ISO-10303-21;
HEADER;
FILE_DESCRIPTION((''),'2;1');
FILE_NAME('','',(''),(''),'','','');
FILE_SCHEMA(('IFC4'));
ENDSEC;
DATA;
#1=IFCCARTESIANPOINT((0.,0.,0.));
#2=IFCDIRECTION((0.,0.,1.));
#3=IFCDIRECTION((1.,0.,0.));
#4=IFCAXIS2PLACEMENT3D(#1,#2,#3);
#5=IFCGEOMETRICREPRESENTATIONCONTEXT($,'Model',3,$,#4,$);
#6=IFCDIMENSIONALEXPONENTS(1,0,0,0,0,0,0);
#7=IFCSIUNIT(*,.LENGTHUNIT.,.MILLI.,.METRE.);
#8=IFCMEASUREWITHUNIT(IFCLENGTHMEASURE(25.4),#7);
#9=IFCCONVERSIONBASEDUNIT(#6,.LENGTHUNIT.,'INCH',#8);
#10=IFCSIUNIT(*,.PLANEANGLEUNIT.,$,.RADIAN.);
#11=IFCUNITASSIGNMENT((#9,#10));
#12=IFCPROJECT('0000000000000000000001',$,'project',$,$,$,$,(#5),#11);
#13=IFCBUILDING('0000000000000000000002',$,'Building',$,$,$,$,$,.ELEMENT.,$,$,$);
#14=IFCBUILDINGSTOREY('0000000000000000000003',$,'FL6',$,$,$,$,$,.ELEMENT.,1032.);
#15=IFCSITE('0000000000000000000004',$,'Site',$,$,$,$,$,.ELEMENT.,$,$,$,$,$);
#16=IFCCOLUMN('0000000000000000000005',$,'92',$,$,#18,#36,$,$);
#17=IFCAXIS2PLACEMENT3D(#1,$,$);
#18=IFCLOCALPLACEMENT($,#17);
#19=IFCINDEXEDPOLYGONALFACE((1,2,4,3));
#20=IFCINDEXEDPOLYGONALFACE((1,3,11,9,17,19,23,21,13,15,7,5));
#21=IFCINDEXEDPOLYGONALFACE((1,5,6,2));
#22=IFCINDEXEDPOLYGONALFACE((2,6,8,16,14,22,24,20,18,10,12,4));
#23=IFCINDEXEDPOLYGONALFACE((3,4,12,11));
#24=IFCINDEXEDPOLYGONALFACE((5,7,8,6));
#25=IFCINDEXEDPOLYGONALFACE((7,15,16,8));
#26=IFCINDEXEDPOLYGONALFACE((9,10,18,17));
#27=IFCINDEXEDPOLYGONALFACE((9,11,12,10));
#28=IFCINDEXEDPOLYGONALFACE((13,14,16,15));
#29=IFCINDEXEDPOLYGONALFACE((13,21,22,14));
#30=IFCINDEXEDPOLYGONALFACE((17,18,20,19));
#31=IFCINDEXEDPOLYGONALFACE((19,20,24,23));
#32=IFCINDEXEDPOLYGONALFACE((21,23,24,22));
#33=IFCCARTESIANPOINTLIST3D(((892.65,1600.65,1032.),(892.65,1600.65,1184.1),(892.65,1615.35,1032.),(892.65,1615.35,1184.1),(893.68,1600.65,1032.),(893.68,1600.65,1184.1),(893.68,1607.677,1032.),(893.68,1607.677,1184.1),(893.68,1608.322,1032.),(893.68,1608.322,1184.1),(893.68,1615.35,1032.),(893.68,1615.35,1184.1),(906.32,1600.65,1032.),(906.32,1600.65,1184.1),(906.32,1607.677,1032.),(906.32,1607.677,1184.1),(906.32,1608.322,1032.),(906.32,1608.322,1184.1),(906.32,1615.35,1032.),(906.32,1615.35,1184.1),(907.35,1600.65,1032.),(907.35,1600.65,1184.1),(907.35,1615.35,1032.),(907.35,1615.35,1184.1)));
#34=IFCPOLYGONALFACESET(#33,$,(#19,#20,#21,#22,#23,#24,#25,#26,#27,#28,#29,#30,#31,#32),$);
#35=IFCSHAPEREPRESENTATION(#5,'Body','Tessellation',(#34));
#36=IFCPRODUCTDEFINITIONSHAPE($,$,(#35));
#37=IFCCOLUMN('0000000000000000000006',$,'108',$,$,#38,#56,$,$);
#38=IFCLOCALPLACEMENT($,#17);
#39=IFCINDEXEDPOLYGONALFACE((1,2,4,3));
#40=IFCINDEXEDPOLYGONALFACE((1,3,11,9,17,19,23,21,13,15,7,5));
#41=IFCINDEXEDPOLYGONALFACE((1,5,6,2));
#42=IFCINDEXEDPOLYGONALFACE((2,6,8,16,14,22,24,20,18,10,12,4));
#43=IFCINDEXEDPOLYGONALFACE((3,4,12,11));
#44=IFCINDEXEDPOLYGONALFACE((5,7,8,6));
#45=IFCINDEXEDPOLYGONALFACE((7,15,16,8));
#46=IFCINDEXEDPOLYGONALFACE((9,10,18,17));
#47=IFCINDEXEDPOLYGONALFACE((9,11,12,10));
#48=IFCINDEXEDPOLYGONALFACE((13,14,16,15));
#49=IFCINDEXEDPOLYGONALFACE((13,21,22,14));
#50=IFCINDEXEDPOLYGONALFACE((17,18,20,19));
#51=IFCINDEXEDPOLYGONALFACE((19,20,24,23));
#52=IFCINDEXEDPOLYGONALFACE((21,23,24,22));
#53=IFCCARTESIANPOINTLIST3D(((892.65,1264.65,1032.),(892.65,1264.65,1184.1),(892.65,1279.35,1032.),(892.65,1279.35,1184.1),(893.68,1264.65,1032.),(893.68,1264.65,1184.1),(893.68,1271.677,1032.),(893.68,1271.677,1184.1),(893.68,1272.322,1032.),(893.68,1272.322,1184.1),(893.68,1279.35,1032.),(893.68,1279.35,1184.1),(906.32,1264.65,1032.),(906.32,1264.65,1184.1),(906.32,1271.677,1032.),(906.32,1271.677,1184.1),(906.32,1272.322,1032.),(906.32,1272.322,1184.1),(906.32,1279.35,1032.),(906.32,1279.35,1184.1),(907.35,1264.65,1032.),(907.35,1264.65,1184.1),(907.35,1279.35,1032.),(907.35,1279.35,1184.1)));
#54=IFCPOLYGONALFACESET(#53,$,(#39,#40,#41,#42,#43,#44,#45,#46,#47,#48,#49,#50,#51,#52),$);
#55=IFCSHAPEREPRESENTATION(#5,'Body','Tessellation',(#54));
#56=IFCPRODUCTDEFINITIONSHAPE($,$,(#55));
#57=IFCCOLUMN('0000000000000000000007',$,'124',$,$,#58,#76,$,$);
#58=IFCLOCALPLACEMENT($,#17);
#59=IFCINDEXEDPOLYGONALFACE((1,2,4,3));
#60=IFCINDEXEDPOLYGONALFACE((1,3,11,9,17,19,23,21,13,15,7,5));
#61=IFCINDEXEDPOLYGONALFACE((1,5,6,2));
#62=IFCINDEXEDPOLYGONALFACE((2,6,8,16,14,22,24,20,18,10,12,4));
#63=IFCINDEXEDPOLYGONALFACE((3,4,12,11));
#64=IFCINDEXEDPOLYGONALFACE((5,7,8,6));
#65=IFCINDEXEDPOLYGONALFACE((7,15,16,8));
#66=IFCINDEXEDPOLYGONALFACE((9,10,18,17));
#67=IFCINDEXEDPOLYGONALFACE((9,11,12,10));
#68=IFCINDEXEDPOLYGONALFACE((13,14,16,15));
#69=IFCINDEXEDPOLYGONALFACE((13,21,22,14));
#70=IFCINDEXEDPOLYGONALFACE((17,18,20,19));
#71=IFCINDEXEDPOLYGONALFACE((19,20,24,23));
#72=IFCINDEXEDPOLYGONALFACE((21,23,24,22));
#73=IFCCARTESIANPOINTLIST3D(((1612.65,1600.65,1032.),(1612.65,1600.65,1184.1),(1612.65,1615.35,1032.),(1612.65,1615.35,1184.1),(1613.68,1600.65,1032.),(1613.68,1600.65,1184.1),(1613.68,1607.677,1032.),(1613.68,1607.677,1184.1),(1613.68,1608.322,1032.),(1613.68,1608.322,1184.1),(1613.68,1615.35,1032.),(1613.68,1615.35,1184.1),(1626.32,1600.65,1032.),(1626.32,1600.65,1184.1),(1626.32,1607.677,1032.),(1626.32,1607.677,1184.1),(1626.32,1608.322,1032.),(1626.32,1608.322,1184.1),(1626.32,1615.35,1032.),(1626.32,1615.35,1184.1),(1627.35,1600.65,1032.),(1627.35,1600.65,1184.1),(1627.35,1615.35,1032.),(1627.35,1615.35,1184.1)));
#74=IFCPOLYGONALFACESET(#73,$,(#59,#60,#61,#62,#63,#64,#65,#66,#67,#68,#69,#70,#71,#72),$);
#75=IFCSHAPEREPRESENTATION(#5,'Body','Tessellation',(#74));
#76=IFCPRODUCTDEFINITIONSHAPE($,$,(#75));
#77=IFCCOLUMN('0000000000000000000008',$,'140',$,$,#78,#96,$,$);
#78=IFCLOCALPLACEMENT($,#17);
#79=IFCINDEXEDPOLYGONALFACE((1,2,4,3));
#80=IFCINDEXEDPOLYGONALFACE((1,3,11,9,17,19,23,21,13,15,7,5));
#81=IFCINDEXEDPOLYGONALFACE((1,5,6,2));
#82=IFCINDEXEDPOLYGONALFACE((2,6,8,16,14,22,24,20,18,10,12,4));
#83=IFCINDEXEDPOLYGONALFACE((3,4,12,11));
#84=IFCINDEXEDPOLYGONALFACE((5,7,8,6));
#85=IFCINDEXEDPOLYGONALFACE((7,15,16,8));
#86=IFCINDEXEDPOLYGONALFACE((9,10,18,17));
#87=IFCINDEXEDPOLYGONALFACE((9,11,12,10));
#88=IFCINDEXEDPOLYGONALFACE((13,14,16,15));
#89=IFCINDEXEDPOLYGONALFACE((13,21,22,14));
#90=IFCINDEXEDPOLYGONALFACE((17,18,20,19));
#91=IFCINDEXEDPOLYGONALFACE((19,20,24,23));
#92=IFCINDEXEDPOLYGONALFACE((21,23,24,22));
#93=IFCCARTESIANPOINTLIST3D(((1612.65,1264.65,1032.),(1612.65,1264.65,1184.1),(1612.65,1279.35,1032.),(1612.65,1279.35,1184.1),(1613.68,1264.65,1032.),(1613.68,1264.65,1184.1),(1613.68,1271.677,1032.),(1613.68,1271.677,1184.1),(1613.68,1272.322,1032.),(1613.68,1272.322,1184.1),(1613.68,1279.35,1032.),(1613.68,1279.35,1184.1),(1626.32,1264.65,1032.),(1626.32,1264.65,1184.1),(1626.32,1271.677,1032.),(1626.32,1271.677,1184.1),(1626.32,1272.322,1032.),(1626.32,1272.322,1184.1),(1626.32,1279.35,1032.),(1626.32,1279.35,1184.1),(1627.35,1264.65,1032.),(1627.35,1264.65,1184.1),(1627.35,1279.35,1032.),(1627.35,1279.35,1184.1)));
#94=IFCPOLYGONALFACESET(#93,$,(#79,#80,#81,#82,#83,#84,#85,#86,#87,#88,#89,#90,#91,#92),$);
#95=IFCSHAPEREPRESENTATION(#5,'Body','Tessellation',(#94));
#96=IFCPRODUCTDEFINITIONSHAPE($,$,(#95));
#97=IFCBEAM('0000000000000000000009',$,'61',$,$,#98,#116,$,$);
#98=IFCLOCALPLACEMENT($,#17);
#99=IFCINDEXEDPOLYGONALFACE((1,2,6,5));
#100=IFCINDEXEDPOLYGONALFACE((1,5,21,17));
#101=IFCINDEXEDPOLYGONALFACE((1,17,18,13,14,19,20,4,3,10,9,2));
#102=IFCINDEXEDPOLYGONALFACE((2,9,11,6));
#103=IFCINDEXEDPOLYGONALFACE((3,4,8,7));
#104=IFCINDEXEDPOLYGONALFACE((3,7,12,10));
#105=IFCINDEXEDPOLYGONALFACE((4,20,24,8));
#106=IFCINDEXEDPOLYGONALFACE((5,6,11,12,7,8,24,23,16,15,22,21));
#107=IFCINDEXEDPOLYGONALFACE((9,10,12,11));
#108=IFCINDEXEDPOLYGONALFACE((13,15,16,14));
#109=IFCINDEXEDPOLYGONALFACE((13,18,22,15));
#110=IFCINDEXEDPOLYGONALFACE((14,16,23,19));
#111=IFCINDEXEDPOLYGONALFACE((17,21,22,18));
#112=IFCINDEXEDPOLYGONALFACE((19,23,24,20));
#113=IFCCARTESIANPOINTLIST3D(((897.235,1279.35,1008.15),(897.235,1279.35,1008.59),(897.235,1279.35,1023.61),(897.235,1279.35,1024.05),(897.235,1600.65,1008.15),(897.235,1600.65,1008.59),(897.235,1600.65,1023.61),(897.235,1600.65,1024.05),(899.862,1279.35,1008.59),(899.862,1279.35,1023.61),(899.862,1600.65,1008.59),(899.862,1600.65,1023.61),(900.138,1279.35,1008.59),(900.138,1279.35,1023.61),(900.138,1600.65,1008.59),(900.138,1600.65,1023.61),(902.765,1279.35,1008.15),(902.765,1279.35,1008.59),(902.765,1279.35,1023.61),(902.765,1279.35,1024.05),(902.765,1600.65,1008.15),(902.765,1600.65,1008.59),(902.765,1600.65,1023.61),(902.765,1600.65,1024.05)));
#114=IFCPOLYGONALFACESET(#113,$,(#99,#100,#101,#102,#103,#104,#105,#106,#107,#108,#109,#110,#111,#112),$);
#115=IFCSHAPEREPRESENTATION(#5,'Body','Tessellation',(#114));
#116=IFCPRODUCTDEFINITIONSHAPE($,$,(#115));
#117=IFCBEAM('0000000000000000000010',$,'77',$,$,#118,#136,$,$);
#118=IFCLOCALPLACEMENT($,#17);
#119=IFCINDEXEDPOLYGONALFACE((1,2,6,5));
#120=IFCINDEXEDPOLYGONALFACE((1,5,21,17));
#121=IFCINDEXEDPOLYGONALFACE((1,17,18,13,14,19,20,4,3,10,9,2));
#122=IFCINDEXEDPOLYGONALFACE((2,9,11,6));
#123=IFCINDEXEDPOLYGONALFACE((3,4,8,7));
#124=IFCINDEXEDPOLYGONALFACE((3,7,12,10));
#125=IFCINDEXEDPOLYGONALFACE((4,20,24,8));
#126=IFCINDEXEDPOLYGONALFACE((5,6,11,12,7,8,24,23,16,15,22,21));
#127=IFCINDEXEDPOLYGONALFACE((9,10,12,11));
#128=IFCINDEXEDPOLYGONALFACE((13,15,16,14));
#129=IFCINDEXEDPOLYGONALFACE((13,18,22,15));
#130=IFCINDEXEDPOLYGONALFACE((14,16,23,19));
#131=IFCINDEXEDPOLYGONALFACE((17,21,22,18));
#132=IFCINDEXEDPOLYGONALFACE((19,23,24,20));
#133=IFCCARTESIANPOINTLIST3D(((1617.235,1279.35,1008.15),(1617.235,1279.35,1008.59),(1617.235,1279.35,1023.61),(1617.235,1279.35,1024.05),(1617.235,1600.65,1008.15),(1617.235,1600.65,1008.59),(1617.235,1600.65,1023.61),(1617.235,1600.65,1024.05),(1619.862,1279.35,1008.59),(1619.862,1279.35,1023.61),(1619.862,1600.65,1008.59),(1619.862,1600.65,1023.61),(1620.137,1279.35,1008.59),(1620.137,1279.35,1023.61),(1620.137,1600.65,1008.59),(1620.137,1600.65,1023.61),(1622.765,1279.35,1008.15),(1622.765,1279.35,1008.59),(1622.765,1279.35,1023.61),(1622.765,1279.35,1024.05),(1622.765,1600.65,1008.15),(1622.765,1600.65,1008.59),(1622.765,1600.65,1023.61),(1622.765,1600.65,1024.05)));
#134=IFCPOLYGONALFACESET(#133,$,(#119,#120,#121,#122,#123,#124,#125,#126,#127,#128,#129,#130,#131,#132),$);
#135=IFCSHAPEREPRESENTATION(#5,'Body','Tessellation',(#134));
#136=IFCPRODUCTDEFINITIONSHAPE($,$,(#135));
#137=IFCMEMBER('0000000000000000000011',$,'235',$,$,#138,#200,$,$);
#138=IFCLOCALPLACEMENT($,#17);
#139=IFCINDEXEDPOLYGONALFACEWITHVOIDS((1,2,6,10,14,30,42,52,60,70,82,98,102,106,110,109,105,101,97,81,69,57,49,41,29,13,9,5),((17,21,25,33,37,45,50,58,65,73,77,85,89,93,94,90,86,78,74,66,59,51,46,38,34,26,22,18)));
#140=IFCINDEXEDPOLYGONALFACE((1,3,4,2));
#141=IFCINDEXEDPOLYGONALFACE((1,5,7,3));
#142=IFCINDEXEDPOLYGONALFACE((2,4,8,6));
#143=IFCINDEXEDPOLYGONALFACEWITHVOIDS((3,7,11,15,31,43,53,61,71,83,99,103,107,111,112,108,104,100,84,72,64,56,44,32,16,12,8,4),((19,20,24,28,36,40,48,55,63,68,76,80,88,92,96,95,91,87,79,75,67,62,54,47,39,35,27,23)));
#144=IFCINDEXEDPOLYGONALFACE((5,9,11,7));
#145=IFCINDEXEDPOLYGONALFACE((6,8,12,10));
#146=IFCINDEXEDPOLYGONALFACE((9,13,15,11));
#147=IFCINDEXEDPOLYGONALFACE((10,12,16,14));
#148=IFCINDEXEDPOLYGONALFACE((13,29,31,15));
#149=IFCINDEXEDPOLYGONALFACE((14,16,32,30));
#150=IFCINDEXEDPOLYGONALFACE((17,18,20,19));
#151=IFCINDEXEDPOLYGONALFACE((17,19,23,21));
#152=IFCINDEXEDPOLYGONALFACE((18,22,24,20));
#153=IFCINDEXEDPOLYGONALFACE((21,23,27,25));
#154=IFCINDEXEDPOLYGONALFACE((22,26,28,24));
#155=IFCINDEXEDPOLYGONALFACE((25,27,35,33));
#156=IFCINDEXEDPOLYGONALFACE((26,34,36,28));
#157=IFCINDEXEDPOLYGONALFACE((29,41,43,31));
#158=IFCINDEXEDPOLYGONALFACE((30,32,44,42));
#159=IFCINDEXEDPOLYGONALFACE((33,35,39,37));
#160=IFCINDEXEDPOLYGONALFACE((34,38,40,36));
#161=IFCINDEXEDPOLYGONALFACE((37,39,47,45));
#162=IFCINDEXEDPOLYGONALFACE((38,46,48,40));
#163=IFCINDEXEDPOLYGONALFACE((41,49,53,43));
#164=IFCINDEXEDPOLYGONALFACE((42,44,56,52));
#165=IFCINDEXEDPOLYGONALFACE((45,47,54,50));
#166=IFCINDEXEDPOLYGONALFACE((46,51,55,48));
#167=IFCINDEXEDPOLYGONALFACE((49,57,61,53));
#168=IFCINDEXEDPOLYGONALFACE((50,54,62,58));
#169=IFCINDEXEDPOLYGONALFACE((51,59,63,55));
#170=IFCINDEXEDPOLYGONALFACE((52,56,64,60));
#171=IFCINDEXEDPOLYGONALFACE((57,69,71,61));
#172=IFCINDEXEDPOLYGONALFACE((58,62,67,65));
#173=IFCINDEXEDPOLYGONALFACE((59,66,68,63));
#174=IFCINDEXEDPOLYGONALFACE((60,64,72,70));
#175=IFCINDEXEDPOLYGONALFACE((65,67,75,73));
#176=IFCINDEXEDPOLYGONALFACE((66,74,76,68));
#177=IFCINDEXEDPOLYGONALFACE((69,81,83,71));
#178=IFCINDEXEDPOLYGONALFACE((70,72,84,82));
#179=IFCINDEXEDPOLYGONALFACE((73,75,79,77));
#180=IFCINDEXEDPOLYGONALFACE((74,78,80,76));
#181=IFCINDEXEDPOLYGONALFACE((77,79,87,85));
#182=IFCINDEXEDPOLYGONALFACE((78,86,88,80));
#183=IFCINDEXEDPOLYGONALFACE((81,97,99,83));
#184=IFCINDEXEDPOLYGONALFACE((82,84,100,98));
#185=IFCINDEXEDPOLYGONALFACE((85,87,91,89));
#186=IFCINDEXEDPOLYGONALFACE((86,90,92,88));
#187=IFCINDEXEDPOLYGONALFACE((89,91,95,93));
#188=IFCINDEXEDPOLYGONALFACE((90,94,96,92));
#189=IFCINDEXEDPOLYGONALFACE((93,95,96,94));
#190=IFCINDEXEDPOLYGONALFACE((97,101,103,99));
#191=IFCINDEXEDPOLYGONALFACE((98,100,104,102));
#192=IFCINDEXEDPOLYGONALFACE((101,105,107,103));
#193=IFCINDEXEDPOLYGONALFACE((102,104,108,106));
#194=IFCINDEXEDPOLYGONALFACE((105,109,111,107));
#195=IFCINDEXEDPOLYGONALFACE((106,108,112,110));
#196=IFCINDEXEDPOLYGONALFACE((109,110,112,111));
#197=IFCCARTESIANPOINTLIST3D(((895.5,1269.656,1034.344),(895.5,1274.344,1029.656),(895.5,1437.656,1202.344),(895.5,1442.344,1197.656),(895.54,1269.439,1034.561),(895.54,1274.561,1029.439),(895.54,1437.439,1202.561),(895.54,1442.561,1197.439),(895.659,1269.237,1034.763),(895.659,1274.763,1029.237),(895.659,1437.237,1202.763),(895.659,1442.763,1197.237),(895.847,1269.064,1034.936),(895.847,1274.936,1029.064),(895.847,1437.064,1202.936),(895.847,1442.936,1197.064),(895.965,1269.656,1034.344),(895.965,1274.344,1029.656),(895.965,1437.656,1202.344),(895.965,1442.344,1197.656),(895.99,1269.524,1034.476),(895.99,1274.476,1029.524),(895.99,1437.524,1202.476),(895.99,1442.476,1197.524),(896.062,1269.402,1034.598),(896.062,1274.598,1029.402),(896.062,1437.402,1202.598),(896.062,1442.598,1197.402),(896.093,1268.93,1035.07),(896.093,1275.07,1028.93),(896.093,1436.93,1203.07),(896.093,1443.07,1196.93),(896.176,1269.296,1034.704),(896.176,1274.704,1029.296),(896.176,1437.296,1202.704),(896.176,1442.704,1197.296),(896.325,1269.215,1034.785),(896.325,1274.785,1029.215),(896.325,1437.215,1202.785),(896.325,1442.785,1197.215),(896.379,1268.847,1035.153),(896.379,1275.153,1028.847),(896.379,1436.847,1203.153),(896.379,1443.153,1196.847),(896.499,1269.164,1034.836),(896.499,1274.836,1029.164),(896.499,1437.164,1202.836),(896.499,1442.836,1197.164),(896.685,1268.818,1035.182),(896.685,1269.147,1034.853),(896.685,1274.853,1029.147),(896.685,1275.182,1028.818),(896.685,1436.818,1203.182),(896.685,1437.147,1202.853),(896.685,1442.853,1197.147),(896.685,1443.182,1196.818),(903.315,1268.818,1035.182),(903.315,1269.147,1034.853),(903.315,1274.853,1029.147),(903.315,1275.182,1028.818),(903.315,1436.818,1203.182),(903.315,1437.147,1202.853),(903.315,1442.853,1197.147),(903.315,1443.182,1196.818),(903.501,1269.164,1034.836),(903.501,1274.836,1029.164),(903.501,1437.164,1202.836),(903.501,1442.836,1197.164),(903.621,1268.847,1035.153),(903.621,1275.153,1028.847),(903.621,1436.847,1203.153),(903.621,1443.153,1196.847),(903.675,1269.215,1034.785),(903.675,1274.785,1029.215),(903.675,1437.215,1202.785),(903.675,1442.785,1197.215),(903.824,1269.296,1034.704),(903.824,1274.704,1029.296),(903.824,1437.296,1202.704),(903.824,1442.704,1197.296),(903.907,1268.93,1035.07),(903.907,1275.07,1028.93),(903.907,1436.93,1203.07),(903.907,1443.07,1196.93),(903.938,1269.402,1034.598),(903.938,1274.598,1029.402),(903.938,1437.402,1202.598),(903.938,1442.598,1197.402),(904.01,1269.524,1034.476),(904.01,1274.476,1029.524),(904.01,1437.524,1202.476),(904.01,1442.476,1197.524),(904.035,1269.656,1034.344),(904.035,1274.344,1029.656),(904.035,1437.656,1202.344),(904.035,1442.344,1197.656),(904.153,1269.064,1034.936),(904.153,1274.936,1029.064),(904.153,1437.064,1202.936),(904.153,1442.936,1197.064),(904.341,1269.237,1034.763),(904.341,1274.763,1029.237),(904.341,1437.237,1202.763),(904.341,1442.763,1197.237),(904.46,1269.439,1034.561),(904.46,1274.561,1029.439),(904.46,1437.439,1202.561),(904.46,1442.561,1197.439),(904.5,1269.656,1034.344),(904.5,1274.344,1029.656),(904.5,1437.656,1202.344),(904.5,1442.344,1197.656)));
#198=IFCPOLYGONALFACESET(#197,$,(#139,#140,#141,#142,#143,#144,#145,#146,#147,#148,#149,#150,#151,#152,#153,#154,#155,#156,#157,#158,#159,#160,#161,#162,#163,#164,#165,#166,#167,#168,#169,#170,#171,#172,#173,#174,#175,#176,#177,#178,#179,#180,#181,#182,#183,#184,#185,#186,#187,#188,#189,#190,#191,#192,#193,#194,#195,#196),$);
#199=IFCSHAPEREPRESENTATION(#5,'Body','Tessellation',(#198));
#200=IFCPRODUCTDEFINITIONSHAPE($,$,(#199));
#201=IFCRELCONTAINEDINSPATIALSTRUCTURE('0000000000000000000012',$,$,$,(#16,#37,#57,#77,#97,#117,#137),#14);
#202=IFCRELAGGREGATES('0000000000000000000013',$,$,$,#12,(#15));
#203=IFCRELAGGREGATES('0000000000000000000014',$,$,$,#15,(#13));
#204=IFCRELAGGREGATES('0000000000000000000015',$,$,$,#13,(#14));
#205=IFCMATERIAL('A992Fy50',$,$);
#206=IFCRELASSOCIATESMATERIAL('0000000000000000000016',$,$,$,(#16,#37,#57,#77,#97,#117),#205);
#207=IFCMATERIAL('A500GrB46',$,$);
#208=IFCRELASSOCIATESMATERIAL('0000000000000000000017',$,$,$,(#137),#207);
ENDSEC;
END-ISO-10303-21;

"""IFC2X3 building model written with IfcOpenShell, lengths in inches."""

from ifc_helpers import new_model, entity, si_unit, converted_unit, frame, origin_with_axes, origin_2d_with_axis, place, context, project, spatial, hollow_rectangle, i_section, transform_2d, derived_profile, extrude, material, element, save


model = new_model("IFC2X3")

# Units and contexts
model_context = context("Model", 3, world=origin_with_axes())
ifc_project = project(units=[converted_unit("LENGTHUNIT", "INCH", entity("IfcLengthMeasure", 25.4), si_unit("LENGTHUNIT", "METRE", prefix="MILLI"), dimensions=[1, 0, 0, 0, 0, 0, 0]), si_unit("PLANEANGLEUNIT", "RADIAN")], contexts=[model_context])

# Site, building, storey
site = spatial("IfcSite", under=ifc_project, Name="Site", CompositionType="ELEMENT")
building = spatial("IfcBuilding", under=site, Name="Building", CompositionType="ELEMENT")
storey = spatial("IfcBuildingStorey", under=building, Name="FL6", CompositionType="ELEMENT", Elevation=1032.0)

# Columns
ifc_material_1 = material(Name="A992Fy50")
for number, where, z_axis, x_axis, name in (
    (1, (900.0, 1608.0, 1032.0), (0.0, 0.0, 1.0), (0.0, -1.0, 0.0), "92"),
    (2, (900.0, 1272.0, 1032.0), (0.0, 0.0, 1.0), (0.0, -1.0, 0.0), "108"),
    (3, (1620.0, 1608.0, 1032.0), (0.0, 0.0, 1.0), (0.0, -1.0, 0.0), "124"),
    (4, (1620.0, 1272.0, 1032.0), (0.0, 0.0, 1.0), (0.0, -1.0, 0.0), "140"),
):
    element("IfcColumn", number, at=place(None, frame(where, z_axis=z_axis, x_axis=x_axis)), inside=storey, material=ifc_material_1, Name=name, context=model_context, shape_type="SweptSolid", body=[
        extrude(i_section(OverallWidth=14.7, OverallDepth=14.7, WebThickness=0.645, FlangeThickness=1.03, at=origin_2d_with_axis()), origin_with_axes(), (0.0, 0.0, 1.0), 152.1),
    ])

# Beams
for number, where, z_axis, x_axis, name in (
    (5, (900.0, 1279.35, 1032.0), (0.0, 1.0, 0.0), (-1.0, 0.0, 0.0), "61"),
    (6, (1620.0, 1279.35, 1032.0), (0.0, 1.0, 0.0), (-1.0, 0.0, 0.0), "77"),
):
    element("IfcBeam", number, at=place(None, frame(where, z_axis=z_axis, x_axis=x_axis)), inside=storey, material=ifc_material_1, Name=name, context=model_context, shape_type="SweptSolid", body=[
        extrude(derived_profile(i_section(OverallWidth=5.53, OverallDepth=15.9, WebThickness=0.275, FlangeThickness=0.44, at=origin_2d_with_axis()), transform_2d((0.0, -7.95))), origin_with_axes(), (0.0, 0.0, 1.0), 321.3),
    ])

# Member
ifc_material_2 = material(Name="A500GrB46")
for number, where, z_axis, x_axis, name in (
    (7, (900.0, 1272.0, 1032.0), (0.0, 0.707107, 0.707107), (-1.0, 0.0, 0.0), "235"),
):
    element("IfcMember", number, at=place(None, frame(where, z_axis=z_axis, x_axis=x_axis)), inside=storey, material=ifc_material_2, Name=name, context=model_context, shape_type="SweptSolid", body=[
        extrude(hollow_rectangle(XDim=9.0, YDim=9.0, WallThickness=0.465, InnerFilletRadius=0.72, OuterFilletRadius=1.185, at=origin_2d_with_axis()), origin_with_axes(), (0.0, 0.0, 1.0), 237.588),
    ])

save(model, "model.ifc")
